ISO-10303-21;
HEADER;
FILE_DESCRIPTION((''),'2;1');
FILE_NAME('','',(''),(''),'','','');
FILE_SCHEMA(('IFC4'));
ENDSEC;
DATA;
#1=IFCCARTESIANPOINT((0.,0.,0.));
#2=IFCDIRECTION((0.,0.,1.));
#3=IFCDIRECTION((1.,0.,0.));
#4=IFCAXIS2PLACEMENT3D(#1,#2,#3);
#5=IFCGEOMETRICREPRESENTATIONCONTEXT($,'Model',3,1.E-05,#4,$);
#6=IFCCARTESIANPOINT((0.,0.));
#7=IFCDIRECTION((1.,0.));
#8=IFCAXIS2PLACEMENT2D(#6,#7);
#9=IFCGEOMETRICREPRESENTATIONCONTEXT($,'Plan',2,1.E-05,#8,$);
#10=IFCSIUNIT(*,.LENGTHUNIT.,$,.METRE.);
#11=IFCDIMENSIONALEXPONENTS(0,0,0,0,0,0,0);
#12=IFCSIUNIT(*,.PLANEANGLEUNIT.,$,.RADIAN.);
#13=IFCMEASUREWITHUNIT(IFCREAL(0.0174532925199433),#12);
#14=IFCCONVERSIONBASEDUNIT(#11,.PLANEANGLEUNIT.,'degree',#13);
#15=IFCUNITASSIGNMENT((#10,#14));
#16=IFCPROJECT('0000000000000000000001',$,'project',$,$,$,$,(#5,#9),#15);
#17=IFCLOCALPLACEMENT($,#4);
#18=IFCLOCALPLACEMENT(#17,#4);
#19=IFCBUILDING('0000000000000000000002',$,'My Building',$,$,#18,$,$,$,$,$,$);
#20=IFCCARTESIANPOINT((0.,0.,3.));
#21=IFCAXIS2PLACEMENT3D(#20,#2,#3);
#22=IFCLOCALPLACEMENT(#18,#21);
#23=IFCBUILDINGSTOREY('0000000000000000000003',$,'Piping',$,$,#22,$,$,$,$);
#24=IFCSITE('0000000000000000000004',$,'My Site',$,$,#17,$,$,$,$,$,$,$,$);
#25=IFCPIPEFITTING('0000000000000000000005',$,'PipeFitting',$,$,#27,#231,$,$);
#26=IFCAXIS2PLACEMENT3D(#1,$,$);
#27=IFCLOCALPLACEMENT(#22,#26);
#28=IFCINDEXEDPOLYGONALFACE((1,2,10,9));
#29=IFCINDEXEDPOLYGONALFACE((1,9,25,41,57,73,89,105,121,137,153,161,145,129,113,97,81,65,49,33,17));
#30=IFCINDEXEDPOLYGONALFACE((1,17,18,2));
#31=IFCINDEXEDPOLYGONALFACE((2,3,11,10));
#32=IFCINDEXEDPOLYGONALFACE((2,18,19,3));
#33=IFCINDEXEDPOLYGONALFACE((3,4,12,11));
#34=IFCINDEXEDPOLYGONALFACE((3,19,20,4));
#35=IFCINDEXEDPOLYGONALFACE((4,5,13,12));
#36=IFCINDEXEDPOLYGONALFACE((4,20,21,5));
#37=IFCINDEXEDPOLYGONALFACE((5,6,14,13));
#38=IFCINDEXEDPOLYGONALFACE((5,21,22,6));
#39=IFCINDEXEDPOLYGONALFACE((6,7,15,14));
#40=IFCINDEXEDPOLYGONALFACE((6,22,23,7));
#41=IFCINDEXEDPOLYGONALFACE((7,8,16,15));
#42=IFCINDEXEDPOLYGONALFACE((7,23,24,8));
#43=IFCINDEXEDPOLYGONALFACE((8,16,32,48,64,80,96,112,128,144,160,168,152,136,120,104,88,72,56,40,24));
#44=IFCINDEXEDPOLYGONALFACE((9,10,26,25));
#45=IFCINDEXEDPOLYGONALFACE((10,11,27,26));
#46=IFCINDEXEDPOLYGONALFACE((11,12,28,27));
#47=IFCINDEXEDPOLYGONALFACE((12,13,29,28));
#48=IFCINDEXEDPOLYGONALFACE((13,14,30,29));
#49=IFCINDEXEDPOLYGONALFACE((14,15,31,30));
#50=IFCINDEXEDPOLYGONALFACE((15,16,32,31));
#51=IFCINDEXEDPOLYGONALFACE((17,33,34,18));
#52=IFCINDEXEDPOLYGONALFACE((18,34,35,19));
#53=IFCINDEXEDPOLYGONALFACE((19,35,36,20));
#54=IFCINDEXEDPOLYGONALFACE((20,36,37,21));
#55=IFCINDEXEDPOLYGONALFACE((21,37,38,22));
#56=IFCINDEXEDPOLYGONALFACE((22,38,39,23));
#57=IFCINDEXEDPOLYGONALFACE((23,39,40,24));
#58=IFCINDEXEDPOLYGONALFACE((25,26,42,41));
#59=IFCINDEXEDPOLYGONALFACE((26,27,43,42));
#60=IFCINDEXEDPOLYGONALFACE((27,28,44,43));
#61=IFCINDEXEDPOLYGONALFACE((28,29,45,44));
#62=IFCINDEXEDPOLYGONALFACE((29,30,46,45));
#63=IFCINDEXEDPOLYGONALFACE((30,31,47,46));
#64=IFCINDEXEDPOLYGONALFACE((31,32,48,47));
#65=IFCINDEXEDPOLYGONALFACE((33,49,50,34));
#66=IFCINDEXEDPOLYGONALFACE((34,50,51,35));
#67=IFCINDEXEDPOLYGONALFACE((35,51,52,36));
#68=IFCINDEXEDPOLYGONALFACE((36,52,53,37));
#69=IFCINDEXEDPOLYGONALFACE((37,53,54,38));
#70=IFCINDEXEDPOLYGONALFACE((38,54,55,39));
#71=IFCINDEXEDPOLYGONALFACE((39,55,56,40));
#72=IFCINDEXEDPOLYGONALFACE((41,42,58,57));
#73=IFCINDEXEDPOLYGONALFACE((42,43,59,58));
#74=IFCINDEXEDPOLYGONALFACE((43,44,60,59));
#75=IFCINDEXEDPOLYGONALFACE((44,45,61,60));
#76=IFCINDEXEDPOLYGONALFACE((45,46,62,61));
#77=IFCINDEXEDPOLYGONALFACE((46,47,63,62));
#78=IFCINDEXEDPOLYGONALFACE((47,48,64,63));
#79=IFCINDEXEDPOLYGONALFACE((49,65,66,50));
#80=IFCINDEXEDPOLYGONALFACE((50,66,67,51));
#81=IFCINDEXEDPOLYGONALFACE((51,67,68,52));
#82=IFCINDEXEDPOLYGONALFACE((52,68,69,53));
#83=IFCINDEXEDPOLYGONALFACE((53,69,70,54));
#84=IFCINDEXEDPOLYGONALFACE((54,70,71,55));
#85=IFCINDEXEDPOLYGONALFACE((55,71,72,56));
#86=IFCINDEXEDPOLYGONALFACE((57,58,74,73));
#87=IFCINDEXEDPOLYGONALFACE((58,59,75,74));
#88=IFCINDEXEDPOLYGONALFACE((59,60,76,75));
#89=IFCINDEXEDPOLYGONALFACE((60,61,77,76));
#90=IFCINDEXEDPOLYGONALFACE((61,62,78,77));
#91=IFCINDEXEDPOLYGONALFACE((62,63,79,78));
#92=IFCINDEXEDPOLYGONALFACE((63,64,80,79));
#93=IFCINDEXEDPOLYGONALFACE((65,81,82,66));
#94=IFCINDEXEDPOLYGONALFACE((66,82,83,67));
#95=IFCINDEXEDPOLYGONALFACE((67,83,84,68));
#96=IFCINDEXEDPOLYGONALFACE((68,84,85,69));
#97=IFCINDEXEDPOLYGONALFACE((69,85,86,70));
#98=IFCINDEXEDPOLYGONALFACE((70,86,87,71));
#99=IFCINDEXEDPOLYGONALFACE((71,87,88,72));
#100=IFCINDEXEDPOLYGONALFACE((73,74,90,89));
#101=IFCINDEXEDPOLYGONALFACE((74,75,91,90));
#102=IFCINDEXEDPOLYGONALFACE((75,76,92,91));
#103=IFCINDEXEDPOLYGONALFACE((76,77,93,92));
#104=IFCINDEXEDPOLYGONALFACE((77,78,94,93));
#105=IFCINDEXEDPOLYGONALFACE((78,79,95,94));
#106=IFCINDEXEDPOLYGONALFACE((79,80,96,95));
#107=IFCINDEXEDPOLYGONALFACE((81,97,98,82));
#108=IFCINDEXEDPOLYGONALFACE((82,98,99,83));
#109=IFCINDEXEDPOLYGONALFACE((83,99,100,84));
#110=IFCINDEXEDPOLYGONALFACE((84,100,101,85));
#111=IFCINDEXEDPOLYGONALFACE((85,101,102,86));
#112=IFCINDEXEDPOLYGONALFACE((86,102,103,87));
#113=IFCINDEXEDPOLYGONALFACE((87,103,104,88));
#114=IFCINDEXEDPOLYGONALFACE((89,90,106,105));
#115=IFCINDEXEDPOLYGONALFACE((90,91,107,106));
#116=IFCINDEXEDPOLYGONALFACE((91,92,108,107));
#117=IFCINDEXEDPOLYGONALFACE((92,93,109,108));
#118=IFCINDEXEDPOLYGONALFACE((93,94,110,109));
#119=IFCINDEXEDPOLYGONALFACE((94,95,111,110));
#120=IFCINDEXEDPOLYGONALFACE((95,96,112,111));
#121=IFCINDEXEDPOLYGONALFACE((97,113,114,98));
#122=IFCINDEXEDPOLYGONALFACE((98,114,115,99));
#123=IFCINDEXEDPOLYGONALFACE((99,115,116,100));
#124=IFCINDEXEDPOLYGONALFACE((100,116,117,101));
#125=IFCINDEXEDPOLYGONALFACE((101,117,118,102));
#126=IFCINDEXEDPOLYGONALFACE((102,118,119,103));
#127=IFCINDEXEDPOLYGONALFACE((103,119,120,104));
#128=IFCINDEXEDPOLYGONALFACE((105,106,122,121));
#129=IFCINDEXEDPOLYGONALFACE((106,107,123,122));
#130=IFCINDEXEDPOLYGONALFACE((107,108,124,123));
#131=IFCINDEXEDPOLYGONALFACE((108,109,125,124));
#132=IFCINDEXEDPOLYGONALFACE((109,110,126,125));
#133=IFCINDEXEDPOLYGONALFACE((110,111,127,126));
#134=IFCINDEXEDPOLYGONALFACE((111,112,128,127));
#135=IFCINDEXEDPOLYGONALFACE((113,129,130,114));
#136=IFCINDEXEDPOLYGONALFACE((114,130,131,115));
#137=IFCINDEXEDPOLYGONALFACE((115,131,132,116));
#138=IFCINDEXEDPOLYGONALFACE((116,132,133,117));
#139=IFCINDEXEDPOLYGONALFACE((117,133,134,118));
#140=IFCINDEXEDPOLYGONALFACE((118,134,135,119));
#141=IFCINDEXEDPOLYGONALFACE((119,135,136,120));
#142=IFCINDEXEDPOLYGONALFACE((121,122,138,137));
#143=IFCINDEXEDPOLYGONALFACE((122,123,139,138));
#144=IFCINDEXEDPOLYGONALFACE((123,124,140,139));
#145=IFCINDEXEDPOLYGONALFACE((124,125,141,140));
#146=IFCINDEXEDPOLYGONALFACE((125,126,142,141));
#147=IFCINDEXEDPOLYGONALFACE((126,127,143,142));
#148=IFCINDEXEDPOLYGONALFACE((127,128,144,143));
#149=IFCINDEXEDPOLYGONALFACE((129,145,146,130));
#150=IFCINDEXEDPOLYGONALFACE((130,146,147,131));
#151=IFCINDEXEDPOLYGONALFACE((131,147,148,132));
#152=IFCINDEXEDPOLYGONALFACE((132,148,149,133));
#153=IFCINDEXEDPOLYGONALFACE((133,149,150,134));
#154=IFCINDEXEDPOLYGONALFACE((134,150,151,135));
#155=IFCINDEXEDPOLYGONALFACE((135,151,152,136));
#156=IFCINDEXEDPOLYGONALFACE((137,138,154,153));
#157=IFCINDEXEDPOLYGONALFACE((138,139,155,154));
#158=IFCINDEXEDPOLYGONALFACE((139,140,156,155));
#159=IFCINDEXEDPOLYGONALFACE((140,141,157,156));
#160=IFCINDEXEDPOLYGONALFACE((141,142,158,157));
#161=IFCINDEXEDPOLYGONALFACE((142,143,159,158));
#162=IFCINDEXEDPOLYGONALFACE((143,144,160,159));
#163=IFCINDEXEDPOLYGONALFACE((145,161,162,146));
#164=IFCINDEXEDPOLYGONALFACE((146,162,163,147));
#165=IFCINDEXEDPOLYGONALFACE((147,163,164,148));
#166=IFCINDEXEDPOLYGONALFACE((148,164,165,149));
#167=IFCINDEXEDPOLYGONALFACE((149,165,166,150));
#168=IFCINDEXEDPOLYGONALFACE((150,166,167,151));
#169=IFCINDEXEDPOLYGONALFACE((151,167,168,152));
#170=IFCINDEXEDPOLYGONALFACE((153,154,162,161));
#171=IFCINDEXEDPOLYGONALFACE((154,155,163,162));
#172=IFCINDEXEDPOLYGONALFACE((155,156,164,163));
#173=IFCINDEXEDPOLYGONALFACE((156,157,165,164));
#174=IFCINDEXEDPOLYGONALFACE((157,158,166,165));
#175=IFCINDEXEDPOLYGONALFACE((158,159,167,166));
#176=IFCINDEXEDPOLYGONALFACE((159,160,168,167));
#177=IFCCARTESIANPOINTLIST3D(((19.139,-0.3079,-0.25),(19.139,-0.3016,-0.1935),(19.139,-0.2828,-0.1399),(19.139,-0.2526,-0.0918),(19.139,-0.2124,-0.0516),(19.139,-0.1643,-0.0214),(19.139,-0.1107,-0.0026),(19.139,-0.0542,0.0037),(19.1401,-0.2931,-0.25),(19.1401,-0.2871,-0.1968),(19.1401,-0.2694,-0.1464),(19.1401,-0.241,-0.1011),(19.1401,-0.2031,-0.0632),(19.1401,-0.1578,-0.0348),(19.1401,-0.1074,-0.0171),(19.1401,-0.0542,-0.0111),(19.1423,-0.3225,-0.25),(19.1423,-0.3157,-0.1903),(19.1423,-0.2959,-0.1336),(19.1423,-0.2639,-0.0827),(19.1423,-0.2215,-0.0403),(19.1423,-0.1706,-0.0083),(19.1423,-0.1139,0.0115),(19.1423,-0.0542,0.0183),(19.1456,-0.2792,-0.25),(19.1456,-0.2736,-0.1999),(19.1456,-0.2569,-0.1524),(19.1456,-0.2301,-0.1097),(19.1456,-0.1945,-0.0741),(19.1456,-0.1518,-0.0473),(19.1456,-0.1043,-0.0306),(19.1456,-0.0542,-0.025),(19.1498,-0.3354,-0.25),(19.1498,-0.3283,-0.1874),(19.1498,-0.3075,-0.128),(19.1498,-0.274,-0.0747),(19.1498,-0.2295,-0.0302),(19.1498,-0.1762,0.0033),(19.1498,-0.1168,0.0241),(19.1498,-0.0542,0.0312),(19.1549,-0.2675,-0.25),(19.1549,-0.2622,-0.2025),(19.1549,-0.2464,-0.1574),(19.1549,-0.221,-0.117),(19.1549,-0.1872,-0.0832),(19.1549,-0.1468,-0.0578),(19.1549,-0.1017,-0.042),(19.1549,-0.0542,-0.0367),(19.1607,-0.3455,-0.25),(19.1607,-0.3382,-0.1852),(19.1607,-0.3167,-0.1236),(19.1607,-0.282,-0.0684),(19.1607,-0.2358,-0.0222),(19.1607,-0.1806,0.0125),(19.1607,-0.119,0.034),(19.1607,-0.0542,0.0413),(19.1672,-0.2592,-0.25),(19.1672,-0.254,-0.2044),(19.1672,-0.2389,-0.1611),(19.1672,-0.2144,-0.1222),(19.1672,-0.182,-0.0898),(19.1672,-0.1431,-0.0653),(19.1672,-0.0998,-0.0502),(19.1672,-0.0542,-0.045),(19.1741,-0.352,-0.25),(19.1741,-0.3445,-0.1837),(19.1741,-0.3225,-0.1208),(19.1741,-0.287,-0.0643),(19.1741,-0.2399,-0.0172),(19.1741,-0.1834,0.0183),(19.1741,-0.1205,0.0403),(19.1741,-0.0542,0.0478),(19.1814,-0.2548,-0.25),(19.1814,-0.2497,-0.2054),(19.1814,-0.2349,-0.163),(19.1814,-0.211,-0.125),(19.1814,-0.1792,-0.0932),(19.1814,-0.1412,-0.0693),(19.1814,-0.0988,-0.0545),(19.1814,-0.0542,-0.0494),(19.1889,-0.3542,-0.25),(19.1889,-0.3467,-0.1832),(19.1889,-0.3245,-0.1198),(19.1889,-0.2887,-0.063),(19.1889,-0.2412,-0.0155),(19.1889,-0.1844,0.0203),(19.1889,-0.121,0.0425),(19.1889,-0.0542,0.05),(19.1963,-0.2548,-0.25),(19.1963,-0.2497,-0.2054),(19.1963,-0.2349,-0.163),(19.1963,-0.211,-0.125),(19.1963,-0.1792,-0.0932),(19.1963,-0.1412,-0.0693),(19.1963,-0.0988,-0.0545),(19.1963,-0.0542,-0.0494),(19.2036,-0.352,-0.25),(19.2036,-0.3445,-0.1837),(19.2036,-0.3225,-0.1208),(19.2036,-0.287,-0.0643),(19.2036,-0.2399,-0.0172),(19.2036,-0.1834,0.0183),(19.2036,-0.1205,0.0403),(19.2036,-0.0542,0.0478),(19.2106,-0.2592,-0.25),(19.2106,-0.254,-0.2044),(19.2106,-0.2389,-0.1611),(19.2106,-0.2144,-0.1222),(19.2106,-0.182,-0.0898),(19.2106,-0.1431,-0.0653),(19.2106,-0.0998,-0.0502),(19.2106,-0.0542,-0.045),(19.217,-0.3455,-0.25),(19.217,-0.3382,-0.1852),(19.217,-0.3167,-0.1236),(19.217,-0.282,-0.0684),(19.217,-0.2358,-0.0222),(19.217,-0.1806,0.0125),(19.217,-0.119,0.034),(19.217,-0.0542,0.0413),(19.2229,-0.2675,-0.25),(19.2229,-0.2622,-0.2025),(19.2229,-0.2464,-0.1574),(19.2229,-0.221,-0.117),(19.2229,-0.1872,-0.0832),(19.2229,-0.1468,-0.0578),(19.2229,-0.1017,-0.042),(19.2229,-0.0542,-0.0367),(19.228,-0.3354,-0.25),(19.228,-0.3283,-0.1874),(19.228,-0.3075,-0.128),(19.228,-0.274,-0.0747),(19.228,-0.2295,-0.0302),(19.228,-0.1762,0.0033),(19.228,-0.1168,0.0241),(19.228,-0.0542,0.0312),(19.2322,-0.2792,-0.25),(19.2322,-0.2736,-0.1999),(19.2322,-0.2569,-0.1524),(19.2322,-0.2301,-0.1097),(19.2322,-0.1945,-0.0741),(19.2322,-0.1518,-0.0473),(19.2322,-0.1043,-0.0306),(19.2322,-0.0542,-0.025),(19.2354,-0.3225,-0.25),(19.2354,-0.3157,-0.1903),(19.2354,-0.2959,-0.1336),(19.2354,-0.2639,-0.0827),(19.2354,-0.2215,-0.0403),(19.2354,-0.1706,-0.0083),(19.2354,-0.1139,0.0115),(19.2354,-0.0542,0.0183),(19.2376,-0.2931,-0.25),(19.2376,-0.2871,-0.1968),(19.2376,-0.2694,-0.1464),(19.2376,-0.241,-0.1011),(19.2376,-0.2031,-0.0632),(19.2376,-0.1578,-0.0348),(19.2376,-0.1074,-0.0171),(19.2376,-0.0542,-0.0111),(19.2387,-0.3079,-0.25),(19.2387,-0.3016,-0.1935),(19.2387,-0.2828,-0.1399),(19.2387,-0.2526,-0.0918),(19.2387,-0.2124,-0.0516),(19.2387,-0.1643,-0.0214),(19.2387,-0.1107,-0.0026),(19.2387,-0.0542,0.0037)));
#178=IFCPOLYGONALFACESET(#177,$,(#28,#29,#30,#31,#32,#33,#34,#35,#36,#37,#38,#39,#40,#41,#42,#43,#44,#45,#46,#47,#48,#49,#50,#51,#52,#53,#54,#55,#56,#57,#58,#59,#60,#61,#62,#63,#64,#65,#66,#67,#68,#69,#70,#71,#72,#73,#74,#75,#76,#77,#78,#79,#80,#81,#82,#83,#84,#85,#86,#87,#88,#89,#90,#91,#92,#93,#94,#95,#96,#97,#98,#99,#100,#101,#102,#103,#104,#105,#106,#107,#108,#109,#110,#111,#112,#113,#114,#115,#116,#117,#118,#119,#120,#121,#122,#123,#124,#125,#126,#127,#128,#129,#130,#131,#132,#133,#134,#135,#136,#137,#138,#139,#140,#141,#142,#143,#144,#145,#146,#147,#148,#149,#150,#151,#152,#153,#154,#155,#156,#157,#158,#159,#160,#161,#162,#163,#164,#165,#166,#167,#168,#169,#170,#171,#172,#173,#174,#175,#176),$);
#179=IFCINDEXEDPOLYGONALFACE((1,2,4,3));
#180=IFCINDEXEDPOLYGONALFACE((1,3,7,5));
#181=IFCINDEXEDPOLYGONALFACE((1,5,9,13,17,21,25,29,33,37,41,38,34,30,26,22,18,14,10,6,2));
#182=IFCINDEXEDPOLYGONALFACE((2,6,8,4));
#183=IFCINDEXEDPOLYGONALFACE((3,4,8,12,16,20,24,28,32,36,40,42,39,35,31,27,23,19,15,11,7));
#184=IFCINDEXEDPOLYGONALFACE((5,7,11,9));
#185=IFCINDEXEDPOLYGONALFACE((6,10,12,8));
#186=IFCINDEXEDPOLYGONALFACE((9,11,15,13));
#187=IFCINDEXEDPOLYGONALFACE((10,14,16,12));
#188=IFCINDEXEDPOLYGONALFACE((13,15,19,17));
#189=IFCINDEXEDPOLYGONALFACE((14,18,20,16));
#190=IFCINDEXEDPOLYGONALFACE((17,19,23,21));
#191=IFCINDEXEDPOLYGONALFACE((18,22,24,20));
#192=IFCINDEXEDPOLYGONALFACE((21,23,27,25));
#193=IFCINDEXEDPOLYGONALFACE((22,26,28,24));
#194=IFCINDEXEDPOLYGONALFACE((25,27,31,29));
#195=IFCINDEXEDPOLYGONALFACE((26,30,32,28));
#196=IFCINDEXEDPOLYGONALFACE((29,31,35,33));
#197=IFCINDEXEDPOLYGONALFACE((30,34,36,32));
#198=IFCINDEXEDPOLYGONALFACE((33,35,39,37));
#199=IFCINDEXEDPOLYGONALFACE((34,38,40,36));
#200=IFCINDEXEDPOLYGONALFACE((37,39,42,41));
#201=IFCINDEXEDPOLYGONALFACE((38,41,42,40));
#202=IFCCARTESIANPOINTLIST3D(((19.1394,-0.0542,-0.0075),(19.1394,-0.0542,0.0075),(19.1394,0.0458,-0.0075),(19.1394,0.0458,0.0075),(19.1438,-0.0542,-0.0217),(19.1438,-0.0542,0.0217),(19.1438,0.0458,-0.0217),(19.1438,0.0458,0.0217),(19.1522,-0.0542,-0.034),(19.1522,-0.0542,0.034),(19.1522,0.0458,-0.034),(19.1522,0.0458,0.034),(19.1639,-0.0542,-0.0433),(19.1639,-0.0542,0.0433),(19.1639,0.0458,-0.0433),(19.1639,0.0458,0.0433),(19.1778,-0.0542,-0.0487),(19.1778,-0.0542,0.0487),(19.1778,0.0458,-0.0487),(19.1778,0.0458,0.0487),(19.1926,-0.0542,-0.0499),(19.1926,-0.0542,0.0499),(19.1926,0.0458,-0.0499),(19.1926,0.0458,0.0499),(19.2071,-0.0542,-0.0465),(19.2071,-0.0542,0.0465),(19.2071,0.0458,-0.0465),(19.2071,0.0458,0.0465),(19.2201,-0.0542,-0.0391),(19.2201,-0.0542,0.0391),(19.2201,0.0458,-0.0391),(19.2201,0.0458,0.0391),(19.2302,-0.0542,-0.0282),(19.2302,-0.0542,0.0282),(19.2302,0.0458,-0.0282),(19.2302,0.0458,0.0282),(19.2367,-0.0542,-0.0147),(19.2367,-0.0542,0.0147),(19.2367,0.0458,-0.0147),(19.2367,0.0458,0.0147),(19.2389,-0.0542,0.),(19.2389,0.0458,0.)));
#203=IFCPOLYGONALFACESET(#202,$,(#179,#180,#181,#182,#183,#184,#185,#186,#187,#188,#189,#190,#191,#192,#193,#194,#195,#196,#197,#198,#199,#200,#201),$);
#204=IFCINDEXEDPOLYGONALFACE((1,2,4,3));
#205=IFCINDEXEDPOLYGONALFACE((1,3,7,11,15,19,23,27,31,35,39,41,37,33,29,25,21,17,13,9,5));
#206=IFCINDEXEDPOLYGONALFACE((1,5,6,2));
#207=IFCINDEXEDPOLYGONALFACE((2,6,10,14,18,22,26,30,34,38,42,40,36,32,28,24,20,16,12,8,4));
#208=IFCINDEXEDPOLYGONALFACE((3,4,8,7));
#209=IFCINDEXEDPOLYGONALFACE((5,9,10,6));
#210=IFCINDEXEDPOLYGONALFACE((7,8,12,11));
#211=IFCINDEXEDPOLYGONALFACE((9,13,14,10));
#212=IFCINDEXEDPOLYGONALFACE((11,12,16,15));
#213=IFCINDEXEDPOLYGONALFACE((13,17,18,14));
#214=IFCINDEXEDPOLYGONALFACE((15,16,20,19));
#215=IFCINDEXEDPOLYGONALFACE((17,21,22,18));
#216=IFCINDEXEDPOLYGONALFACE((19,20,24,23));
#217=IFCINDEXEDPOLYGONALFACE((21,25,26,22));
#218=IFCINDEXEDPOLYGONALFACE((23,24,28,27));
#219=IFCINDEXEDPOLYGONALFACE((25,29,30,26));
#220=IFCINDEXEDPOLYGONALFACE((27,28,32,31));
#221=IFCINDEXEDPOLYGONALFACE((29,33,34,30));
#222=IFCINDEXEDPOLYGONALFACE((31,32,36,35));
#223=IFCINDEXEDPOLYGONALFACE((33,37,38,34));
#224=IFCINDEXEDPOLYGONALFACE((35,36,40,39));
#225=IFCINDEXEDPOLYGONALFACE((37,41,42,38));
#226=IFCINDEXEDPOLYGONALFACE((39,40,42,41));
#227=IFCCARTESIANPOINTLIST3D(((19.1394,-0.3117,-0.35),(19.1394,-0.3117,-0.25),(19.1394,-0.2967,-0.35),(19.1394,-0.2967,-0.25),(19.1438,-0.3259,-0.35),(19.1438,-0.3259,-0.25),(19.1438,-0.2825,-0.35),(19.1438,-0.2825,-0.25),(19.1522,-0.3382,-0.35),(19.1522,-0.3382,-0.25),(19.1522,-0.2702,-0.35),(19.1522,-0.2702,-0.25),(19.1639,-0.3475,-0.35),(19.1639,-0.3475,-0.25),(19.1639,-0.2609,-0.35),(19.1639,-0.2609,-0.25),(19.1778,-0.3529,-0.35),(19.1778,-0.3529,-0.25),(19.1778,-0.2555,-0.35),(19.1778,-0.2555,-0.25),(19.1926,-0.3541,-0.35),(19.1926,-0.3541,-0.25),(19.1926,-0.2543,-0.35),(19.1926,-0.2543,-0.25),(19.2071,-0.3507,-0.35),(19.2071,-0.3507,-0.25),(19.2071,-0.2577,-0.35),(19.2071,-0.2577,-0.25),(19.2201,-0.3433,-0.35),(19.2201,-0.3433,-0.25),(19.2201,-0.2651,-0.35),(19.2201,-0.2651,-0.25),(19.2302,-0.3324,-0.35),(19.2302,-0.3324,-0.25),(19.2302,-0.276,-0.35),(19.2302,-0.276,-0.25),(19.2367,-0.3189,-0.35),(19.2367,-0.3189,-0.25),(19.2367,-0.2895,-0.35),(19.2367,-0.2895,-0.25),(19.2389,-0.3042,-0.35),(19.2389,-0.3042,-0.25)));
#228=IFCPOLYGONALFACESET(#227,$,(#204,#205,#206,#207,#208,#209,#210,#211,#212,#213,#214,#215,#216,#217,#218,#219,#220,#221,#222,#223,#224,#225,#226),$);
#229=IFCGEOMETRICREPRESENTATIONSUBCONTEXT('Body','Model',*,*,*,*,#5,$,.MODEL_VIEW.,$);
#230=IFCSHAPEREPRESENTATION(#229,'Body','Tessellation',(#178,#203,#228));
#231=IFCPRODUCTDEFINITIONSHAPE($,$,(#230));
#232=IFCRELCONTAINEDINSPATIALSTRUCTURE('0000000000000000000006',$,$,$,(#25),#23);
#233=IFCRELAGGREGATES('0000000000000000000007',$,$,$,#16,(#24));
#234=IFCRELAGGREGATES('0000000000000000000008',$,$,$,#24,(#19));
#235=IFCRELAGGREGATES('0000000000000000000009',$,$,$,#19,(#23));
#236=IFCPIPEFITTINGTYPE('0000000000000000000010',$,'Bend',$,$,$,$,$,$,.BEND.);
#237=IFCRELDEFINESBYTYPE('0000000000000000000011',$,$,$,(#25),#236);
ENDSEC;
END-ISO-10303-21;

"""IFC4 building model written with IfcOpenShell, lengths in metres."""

from ifc_helpers import new_model, entity, si_unit, converted_unit, frame, origin_with_axes, origin_2d_with_axis, place, context, subcontext, project, spatial, line, indexed_curve, circle, outline, extrude, source, transform, mapped, type_object, type_shapes, element, save


model = new_model("IFC4")

# Units and contexts
model_context = context("Model", 3, precision=1e-05, world=origin_with_axes())
plan_context = context("Plan", 2, precision=1e-05, world=origin_2d_with_axis())
body_context = subcontext(model_context, "Body", "Model", "MODEL_VIEW")
ifc_project = project(units=[si_unit("LENGTHUNIT", "METRE"), converted_unit("PLANEANGLEUNIT", "degree", entity("IfcReal", 0.0174532925199433), si_unit("PLANEANGLEUNIT", "RADIAN"), dimensions=[0, 0, 0, 0, 0, 0, 0])], contexts=[model_context, plan_context])

# Site, building, storey
site_placement = place(None, origin_with_axes())
site = spatial("IfcSite", under=ifc_project, at=site_placement, Name="My Site")
building_placement = place(site_placement, origin_with_axes())
building = spatial("IfcBuilding", under=site, at=building_placement, Name="My Building")
storey_placement = place(building_placement, frame((0.0, 0.0, 3.0), z_axis=(0.0, 0.0, 1.0), x_axis=(1.0, 0.0, 0.0)))
storey = spatial("IfcBuildingStorey", under=building, at=storey_placement, Name="Piping")

# Pipe fitting, openings
pipe_fitting_type = type_object("IfcPipeFittingType", Name="Bend", PredefinedType="BEND")
shared_shape = source(origin_with_axes(), body_context, "Body", "SolidModel", [
    entity("IfcSweptDiskSolid", entity("IfcIndexedPolyCurve", entity("IfcCartesianPointList3D", [[0.0, 0.0, -0.1], [0.0, 0.0732, -0.2768], [0.0, 0.25, -0.35]]), [entity("IfcArcIndex", [1, 2, 3])]), 0.05),
    extrude(circle(Radius=0.05), origin_with_axes(), (0.0, 0.0, -1.0), 0.1),
    extrude(circle(Radius=0.05), frame((0.0, 0.25, -0.35), z_axis=(0.0, 1.0, 0.0), x_axis=(1.0, 0.0, 0.0)), (0.0, 0.0, 1.0), 0.1),
])
type_shapes(pipe_fitting_type, [shared_shape])
pipe_fitting_placement = place(storey_placement, frame((19.1889, 0.0458, 0.0), z_axis=(0.0, 1.0, 0.0), x_axis=(1.0, 0.0, 0.0)))
pipe_fitting = element("IfcPipeFitting", 1, at=pipe_fitting_placement, inside=storey, type_object=pipe_fitting_type, Name="PipeFitting", context=body_context, shape_type="MappedRepresentation", body=[
    mapped(shared_shape, transform((0.0, 0.0, 0.0), x_axis=(1.0, 0.0, 0.0), y_axis=(0.0, 1.0, 0.0), z_axis=(0.0, 0.0, 1.0), scale=1.0)),
])
opening_1_placement = place(pipe_fitting_placement, frame((-2.1016, 3.0, -1.8188), z_axis=(0.0, -1.0, 0.0), x_axis=(1.0, 0.0, 0.0)))
element("IfcOpeningElement", 2, at=opening_1_placement, cuts=pipe_fitting, PredefinedType="OPENING", context=body_context, shape_type="SweptSolid", body=[
    extrude(outline(indexed_curve([(0.0, 0.0), (0.5, 0.0), (0.5, 0.5), (0.0, 0.5)], segments=[line(1, 2, 3, 4, 1)])), origin_with_axes(), (0.0, 0.0, 1.0), 0.5),
])
opening_2_placement = place(pipe_fitting_placement, frame((-2.1016, 3.0, -1.8188), z_axis=(0.0, -1.0, 0.0), x_axis=(1.0, 0.0, 0.0)))
element("IfcOpeningElement", 3, at=opening_2_placement, cuts=pipe_fitting, PredefinedType="OPENING", context=body_context, shape_type="SweptSolid", body=[
    extrude(outline(indexed_curve([(0.0, 0.0), (0.5, 0.0), (0.5, 0.5), (0.0, 0.5)], segments=[line(1, 2, 3, 4, 1)])), origin_with_axes(), (0.0, 0.0, 1.0), 0.5),
])

save(model, "model.ifc")
